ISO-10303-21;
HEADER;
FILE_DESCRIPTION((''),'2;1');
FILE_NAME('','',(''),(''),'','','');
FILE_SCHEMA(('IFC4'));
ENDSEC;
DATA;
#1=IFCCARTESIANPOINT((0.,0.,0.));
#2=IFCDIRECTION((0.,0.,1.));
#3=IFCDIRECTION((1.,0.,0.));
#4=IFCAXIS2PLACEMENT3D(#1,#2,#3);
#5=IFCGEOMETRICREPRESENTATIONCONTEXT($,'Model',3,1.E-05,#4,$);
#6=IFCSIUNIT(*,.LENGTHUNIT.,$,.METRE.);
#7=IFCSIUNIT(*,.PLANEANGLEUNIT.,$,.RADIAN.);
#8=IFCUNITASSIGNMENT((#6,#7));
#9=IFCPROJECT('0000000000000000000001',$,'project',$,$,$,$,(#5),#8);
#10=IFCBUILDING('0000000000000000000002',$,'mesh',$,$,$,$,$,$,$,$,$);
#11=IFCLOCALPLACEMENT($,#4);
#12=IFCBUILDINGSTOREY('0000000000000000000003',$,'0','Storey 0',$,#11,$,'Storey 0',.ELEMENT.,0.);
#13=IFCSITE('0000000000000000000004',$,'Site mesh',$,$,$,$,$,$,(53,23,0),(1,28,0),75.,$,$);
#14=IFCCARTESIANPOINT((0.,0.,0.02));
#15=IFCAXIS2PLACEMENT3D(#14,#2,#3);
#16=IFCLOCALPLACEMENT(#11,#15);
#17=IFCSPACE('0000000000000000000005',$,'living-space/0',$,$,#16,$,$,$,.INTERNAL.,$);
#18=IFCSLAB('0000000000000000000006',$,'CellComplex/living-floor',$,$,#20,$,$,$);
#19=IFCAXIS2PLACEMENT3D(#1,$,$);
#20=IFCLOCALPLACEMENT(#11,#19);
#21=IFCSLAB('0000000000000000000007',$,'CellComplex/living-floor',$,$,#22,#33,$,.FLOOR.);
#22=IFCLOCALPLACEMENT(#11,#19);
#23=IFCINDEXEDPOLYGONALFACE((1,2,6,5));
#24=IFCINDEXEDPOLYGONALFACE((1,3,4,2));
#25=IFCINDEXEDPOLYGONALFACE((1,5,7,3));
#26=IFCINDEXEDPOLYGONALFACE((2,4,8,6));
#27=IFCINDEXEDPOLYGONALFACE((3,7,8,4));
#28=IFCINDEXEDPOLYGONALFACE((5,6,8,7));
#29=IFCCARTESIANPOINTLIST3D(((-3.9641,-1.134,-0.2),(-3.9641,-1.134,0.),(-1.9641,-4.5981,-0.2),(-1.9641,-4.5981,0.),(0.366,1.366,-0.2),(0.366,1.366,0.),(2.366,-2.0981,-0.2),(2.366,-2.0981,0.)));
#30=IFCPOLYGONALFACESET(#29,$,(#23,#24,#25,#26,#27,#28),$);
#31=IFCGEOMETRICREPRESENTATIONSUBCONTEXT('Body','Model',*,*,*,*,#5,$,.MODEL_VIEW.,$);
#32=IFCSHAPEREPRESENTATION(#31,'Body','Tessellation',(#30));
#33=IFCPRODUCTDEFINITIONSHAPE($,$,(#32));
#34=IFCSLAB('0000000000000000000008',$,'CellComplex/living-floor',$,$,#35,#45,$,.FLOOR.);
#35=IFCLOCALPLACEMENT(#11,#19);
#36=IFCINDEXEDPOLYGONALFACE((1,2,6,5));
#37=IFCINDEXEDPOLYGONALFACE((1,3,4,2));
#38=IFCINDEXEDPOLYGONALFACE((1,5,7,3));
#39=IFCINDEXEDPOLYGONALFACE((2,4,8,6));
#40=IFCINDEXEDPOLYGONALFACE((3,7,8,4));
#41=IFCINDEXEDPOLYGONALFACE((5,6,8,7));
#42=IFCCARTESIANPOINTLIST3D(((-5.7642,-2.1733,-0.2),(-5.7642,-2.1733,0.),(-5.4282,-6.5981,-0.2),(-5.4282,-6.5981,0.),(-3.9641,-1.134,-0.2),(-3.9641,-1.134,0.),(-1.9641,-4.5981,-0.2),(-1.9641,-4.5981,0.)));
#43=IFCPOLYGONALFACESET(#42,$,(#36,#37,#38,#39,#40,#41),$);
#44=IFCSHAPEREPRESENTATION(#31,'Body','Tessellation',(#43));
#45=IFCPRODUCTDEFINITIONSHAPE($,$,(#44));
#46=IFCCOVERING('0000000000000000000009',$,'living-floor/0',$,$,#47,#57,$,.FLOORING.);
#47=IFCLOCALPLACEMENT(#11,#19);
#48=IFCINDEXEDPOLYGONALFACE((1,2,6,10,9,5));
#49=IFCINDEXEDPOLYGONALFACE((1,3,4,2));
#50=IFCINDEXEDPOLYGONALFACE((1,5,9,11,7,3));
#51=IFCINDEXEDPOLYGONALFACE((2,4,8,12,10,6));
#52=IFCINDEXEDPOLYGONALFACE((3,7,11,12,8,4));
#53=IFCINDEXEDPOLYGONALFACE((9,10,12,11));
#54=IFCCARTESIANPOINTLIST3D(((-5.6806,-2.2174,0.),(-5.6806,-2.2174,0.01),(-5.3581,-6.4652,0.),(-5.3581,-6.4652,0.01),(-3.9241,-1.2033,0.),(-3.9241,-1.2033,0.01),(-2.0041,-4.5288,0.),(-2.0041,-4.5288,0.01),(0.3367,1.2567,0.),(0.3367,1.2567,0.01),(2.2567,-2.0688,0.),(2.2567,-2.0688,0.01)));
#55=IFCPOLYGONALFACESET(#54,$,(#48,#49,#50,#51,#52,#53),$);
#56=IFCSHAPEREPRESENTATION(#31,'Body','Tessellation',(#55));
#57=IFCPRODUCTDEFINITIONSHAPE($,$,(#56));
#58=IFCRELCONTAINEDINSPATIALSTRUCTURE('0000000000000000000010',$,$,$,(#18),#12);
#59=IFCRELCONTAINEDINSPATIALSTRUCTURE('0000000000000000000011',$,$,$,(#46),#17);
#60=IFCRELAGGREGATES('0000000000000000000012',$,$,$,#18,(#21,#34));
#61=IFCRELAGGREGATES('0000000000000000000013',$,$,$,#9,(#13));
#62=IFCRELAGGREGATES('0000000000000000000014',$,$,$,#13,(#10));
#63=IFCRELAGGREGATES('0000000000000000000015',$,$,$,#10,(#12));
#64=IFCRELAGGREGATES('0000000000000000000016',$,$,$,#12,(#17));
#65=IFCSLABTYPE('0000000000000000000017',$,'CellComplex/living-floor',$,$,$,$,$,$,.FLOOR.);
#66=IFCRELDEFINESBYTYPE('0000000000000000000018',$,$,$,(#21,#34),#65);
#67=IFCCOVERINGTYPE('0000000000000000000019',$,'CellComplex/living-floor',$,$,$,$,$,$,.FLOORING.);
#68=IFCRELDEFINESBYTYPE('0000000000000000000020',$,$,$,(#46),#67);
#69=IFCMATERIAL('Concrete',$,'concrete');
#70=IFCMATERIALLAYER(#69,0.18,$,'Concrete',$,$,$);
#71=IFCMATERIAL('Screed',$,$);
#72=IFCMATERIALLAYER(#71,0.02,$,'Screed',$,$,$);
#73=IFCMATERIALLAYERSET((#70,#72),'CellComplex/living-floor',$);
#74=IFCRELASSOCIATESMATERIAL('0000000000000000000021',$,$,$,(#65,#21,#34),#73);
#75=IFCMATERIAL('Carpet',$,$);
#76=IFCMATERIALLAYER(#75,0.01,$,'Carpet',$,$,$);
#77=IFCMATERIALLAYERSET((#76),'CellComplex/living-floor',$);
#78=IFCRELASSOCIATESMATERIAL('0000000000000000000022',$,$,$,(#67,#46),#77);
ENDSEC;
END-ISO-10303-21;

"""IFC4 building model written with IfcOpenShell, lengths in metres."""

from ifc_helpers import new_model, si_unit, frame, origin, origin_with_axes, place, context, subcontext, project, spatial, polyline, outline, extrude, material, layer, layer_set, layer_usage, type_object, element, aggregate, save


model = new_model("IFC4")

# Units and contexts
model_context = context("Model", 3, precision=1e-05, world=origin_with_axes())
body_context = subcontext(model_context, "Body", "Model", "MODEL_VIEW")
ifc_project = project(units=[si_unit("LENGTHUNIT", "METRE"), si_unit("PLANEANGLEUNIT", "RADIAN")], contexts=[model_context])

# Site, building, storey
site = spatial("IfcSite", under=ifc_project, Name="Site mesh", RefLatitude=(53, 23, 0), RefLongitude=(1, 28, 0), RefElevation=75.0)
building = spatial("IfcBuilding", under=site, Name="mesh")
storey_placement = place(None, origin_with_axes())
storey = spatial("IfcBuildingStorey", under=building, at=storey_placement, Name="0", Description="Storey 0", LongName="Storey 0", CompositionType="ELEMENT", Elevation=0.0)

# Shared definitions
ifc_material_1 = material(Name="Concrete", Category="concrete")

# Slabs
slab_1_placement = place(storey_placement, origin_with_axes())
slab_1 = element("IfcSlab", 1, at=slab_1_placement, inside=storey, Name="CellComplex/living-floor")
ifc_layer_1 = layer(ifc_material_1, 0.18, Name="Concrete")
ifc_material_2 = material(Name="Screed")
ifc_layer_2 = layer(ifc_material_2, 0.02, Name="Screed")
ifc_layer_set_1 = layer_set([ifc_layer_1, ifc_layer_2], Name="CellComplex/living-floor")
ifc_layer_usage_1 = layer_usage(ifc_layer_set_1, "AXIS3", "POSITIVE", 0.0)
slab_type = type_object("IfcSlabType", Name="CellComplex/living-floor", PredefinedType="FLOOR", material=ifc_layer_set_1)
slab_2_placement = place(slab_1_placement, frame((0.366, 1.366, -0.2), z_axis=(0.0, 0.0, -1.0), x_axis=(0.0, 1.0, 0.0)))
slab_2 = element("IfcSlab", 2, at=slab_2_placement, type_object=slab_type, material=ifc_layer_usage_1, Name="CellComplex/living-floor", PredefinedType="FLOOR", context=body_context, shape_type="SweptSolid", body=[
    extrude(outline(polyline([(0.0, 0.0), (-3.4641, 2.0), (-5.9641, -2.3301), (-2.5, -4.3301), (0.0, 0.0)])), origin(), (0.0, 0.0, -1.0), 0.2),
])
ifc_layer_usage_2 = layer_usage(ifc_layer_set_1, "AXIS3", "POSITIVE", 0.0)
slab_3_placement = place(slab_1_placement, frame((-5.4282, -6.5981, -0.2), z_axis=(0.0, 0.0, -1.0), x_axis=(0.0, 1.0, 0.0)))
slab_3 = element("IfcSlab", 3, at=slab_3_placement, type_object=slab_type, material=ifc_layer_usage_2, Name="CellComplex/living-floor", PredefinedType="FLOOR", context=body_context, shape_type="SweptSolid", body=[
    extrude(outline(polyline([(0.0, 0.0), (4.4248, -0.336), (5.4641, 1.4641), (2.0, 3.4641), (0.0, 0.0)])), origin(), (0.0, 0.0, -1.0), 0.2),
])
aggregate(slab_1, [slab_2, slab_3])

# Shared definitions
space_placement = place(storey_placement, frame((0.0, 0.0, 0.02), z_axis=(0.0, 0.0, 1.0), x_axis=(1.0, 0.0, 0.0)))
space = spatial("IfcSpace", under=storey, at=space_placement, Name="living-space/0", PredefinedType="INTERNAL")

# Covering
ifc_material_3 = material(Name="Carpet")
ifc_layer_3 = layer(ifc_material_3, 0.01, Name="Carpet")
ifc_layer_set_2 = layer_set([ifc_layer_3], Name="CellComplex/living-floor")
ifc_layer_usage_3 = layer_usage(ifc_layer_set_2, "AXIS2", "POSITIVE", 0.0)
covering_type = type_object("IfcCoveringType", Name="CellComplex/living-floor", PredefinedType="FLOORING", material=ifc_layer_set_2)
covering_placement = place(space_placement, frame((0.0, 0.0, -0.02), z_axis=(0.0, 0.0, 1.0), x_axis=(1.0, 0.0, 0.0)))
element("IfcCovering", 4, at=covering_placement, inside=space, type_object=covering_type, material=ifc_layer_usage_3, Name="living-floor/0", PredefinedType="FLOORING", context=body_context, shape_type="SweptSolid", body=[
    extrude(outline(polyline([(-2.0041, -4.5288), (2.2567, -2.0688), (0.3367, 1.2567), (-3.9241, -1.2033), (-5.6806, -2.2174), (-5.3581, -6.4652), (-2.0041, -4.5288)])), origin(), (0.0, 0.0, 1.0), 0.01),
])

save(model, "model.ifc")
